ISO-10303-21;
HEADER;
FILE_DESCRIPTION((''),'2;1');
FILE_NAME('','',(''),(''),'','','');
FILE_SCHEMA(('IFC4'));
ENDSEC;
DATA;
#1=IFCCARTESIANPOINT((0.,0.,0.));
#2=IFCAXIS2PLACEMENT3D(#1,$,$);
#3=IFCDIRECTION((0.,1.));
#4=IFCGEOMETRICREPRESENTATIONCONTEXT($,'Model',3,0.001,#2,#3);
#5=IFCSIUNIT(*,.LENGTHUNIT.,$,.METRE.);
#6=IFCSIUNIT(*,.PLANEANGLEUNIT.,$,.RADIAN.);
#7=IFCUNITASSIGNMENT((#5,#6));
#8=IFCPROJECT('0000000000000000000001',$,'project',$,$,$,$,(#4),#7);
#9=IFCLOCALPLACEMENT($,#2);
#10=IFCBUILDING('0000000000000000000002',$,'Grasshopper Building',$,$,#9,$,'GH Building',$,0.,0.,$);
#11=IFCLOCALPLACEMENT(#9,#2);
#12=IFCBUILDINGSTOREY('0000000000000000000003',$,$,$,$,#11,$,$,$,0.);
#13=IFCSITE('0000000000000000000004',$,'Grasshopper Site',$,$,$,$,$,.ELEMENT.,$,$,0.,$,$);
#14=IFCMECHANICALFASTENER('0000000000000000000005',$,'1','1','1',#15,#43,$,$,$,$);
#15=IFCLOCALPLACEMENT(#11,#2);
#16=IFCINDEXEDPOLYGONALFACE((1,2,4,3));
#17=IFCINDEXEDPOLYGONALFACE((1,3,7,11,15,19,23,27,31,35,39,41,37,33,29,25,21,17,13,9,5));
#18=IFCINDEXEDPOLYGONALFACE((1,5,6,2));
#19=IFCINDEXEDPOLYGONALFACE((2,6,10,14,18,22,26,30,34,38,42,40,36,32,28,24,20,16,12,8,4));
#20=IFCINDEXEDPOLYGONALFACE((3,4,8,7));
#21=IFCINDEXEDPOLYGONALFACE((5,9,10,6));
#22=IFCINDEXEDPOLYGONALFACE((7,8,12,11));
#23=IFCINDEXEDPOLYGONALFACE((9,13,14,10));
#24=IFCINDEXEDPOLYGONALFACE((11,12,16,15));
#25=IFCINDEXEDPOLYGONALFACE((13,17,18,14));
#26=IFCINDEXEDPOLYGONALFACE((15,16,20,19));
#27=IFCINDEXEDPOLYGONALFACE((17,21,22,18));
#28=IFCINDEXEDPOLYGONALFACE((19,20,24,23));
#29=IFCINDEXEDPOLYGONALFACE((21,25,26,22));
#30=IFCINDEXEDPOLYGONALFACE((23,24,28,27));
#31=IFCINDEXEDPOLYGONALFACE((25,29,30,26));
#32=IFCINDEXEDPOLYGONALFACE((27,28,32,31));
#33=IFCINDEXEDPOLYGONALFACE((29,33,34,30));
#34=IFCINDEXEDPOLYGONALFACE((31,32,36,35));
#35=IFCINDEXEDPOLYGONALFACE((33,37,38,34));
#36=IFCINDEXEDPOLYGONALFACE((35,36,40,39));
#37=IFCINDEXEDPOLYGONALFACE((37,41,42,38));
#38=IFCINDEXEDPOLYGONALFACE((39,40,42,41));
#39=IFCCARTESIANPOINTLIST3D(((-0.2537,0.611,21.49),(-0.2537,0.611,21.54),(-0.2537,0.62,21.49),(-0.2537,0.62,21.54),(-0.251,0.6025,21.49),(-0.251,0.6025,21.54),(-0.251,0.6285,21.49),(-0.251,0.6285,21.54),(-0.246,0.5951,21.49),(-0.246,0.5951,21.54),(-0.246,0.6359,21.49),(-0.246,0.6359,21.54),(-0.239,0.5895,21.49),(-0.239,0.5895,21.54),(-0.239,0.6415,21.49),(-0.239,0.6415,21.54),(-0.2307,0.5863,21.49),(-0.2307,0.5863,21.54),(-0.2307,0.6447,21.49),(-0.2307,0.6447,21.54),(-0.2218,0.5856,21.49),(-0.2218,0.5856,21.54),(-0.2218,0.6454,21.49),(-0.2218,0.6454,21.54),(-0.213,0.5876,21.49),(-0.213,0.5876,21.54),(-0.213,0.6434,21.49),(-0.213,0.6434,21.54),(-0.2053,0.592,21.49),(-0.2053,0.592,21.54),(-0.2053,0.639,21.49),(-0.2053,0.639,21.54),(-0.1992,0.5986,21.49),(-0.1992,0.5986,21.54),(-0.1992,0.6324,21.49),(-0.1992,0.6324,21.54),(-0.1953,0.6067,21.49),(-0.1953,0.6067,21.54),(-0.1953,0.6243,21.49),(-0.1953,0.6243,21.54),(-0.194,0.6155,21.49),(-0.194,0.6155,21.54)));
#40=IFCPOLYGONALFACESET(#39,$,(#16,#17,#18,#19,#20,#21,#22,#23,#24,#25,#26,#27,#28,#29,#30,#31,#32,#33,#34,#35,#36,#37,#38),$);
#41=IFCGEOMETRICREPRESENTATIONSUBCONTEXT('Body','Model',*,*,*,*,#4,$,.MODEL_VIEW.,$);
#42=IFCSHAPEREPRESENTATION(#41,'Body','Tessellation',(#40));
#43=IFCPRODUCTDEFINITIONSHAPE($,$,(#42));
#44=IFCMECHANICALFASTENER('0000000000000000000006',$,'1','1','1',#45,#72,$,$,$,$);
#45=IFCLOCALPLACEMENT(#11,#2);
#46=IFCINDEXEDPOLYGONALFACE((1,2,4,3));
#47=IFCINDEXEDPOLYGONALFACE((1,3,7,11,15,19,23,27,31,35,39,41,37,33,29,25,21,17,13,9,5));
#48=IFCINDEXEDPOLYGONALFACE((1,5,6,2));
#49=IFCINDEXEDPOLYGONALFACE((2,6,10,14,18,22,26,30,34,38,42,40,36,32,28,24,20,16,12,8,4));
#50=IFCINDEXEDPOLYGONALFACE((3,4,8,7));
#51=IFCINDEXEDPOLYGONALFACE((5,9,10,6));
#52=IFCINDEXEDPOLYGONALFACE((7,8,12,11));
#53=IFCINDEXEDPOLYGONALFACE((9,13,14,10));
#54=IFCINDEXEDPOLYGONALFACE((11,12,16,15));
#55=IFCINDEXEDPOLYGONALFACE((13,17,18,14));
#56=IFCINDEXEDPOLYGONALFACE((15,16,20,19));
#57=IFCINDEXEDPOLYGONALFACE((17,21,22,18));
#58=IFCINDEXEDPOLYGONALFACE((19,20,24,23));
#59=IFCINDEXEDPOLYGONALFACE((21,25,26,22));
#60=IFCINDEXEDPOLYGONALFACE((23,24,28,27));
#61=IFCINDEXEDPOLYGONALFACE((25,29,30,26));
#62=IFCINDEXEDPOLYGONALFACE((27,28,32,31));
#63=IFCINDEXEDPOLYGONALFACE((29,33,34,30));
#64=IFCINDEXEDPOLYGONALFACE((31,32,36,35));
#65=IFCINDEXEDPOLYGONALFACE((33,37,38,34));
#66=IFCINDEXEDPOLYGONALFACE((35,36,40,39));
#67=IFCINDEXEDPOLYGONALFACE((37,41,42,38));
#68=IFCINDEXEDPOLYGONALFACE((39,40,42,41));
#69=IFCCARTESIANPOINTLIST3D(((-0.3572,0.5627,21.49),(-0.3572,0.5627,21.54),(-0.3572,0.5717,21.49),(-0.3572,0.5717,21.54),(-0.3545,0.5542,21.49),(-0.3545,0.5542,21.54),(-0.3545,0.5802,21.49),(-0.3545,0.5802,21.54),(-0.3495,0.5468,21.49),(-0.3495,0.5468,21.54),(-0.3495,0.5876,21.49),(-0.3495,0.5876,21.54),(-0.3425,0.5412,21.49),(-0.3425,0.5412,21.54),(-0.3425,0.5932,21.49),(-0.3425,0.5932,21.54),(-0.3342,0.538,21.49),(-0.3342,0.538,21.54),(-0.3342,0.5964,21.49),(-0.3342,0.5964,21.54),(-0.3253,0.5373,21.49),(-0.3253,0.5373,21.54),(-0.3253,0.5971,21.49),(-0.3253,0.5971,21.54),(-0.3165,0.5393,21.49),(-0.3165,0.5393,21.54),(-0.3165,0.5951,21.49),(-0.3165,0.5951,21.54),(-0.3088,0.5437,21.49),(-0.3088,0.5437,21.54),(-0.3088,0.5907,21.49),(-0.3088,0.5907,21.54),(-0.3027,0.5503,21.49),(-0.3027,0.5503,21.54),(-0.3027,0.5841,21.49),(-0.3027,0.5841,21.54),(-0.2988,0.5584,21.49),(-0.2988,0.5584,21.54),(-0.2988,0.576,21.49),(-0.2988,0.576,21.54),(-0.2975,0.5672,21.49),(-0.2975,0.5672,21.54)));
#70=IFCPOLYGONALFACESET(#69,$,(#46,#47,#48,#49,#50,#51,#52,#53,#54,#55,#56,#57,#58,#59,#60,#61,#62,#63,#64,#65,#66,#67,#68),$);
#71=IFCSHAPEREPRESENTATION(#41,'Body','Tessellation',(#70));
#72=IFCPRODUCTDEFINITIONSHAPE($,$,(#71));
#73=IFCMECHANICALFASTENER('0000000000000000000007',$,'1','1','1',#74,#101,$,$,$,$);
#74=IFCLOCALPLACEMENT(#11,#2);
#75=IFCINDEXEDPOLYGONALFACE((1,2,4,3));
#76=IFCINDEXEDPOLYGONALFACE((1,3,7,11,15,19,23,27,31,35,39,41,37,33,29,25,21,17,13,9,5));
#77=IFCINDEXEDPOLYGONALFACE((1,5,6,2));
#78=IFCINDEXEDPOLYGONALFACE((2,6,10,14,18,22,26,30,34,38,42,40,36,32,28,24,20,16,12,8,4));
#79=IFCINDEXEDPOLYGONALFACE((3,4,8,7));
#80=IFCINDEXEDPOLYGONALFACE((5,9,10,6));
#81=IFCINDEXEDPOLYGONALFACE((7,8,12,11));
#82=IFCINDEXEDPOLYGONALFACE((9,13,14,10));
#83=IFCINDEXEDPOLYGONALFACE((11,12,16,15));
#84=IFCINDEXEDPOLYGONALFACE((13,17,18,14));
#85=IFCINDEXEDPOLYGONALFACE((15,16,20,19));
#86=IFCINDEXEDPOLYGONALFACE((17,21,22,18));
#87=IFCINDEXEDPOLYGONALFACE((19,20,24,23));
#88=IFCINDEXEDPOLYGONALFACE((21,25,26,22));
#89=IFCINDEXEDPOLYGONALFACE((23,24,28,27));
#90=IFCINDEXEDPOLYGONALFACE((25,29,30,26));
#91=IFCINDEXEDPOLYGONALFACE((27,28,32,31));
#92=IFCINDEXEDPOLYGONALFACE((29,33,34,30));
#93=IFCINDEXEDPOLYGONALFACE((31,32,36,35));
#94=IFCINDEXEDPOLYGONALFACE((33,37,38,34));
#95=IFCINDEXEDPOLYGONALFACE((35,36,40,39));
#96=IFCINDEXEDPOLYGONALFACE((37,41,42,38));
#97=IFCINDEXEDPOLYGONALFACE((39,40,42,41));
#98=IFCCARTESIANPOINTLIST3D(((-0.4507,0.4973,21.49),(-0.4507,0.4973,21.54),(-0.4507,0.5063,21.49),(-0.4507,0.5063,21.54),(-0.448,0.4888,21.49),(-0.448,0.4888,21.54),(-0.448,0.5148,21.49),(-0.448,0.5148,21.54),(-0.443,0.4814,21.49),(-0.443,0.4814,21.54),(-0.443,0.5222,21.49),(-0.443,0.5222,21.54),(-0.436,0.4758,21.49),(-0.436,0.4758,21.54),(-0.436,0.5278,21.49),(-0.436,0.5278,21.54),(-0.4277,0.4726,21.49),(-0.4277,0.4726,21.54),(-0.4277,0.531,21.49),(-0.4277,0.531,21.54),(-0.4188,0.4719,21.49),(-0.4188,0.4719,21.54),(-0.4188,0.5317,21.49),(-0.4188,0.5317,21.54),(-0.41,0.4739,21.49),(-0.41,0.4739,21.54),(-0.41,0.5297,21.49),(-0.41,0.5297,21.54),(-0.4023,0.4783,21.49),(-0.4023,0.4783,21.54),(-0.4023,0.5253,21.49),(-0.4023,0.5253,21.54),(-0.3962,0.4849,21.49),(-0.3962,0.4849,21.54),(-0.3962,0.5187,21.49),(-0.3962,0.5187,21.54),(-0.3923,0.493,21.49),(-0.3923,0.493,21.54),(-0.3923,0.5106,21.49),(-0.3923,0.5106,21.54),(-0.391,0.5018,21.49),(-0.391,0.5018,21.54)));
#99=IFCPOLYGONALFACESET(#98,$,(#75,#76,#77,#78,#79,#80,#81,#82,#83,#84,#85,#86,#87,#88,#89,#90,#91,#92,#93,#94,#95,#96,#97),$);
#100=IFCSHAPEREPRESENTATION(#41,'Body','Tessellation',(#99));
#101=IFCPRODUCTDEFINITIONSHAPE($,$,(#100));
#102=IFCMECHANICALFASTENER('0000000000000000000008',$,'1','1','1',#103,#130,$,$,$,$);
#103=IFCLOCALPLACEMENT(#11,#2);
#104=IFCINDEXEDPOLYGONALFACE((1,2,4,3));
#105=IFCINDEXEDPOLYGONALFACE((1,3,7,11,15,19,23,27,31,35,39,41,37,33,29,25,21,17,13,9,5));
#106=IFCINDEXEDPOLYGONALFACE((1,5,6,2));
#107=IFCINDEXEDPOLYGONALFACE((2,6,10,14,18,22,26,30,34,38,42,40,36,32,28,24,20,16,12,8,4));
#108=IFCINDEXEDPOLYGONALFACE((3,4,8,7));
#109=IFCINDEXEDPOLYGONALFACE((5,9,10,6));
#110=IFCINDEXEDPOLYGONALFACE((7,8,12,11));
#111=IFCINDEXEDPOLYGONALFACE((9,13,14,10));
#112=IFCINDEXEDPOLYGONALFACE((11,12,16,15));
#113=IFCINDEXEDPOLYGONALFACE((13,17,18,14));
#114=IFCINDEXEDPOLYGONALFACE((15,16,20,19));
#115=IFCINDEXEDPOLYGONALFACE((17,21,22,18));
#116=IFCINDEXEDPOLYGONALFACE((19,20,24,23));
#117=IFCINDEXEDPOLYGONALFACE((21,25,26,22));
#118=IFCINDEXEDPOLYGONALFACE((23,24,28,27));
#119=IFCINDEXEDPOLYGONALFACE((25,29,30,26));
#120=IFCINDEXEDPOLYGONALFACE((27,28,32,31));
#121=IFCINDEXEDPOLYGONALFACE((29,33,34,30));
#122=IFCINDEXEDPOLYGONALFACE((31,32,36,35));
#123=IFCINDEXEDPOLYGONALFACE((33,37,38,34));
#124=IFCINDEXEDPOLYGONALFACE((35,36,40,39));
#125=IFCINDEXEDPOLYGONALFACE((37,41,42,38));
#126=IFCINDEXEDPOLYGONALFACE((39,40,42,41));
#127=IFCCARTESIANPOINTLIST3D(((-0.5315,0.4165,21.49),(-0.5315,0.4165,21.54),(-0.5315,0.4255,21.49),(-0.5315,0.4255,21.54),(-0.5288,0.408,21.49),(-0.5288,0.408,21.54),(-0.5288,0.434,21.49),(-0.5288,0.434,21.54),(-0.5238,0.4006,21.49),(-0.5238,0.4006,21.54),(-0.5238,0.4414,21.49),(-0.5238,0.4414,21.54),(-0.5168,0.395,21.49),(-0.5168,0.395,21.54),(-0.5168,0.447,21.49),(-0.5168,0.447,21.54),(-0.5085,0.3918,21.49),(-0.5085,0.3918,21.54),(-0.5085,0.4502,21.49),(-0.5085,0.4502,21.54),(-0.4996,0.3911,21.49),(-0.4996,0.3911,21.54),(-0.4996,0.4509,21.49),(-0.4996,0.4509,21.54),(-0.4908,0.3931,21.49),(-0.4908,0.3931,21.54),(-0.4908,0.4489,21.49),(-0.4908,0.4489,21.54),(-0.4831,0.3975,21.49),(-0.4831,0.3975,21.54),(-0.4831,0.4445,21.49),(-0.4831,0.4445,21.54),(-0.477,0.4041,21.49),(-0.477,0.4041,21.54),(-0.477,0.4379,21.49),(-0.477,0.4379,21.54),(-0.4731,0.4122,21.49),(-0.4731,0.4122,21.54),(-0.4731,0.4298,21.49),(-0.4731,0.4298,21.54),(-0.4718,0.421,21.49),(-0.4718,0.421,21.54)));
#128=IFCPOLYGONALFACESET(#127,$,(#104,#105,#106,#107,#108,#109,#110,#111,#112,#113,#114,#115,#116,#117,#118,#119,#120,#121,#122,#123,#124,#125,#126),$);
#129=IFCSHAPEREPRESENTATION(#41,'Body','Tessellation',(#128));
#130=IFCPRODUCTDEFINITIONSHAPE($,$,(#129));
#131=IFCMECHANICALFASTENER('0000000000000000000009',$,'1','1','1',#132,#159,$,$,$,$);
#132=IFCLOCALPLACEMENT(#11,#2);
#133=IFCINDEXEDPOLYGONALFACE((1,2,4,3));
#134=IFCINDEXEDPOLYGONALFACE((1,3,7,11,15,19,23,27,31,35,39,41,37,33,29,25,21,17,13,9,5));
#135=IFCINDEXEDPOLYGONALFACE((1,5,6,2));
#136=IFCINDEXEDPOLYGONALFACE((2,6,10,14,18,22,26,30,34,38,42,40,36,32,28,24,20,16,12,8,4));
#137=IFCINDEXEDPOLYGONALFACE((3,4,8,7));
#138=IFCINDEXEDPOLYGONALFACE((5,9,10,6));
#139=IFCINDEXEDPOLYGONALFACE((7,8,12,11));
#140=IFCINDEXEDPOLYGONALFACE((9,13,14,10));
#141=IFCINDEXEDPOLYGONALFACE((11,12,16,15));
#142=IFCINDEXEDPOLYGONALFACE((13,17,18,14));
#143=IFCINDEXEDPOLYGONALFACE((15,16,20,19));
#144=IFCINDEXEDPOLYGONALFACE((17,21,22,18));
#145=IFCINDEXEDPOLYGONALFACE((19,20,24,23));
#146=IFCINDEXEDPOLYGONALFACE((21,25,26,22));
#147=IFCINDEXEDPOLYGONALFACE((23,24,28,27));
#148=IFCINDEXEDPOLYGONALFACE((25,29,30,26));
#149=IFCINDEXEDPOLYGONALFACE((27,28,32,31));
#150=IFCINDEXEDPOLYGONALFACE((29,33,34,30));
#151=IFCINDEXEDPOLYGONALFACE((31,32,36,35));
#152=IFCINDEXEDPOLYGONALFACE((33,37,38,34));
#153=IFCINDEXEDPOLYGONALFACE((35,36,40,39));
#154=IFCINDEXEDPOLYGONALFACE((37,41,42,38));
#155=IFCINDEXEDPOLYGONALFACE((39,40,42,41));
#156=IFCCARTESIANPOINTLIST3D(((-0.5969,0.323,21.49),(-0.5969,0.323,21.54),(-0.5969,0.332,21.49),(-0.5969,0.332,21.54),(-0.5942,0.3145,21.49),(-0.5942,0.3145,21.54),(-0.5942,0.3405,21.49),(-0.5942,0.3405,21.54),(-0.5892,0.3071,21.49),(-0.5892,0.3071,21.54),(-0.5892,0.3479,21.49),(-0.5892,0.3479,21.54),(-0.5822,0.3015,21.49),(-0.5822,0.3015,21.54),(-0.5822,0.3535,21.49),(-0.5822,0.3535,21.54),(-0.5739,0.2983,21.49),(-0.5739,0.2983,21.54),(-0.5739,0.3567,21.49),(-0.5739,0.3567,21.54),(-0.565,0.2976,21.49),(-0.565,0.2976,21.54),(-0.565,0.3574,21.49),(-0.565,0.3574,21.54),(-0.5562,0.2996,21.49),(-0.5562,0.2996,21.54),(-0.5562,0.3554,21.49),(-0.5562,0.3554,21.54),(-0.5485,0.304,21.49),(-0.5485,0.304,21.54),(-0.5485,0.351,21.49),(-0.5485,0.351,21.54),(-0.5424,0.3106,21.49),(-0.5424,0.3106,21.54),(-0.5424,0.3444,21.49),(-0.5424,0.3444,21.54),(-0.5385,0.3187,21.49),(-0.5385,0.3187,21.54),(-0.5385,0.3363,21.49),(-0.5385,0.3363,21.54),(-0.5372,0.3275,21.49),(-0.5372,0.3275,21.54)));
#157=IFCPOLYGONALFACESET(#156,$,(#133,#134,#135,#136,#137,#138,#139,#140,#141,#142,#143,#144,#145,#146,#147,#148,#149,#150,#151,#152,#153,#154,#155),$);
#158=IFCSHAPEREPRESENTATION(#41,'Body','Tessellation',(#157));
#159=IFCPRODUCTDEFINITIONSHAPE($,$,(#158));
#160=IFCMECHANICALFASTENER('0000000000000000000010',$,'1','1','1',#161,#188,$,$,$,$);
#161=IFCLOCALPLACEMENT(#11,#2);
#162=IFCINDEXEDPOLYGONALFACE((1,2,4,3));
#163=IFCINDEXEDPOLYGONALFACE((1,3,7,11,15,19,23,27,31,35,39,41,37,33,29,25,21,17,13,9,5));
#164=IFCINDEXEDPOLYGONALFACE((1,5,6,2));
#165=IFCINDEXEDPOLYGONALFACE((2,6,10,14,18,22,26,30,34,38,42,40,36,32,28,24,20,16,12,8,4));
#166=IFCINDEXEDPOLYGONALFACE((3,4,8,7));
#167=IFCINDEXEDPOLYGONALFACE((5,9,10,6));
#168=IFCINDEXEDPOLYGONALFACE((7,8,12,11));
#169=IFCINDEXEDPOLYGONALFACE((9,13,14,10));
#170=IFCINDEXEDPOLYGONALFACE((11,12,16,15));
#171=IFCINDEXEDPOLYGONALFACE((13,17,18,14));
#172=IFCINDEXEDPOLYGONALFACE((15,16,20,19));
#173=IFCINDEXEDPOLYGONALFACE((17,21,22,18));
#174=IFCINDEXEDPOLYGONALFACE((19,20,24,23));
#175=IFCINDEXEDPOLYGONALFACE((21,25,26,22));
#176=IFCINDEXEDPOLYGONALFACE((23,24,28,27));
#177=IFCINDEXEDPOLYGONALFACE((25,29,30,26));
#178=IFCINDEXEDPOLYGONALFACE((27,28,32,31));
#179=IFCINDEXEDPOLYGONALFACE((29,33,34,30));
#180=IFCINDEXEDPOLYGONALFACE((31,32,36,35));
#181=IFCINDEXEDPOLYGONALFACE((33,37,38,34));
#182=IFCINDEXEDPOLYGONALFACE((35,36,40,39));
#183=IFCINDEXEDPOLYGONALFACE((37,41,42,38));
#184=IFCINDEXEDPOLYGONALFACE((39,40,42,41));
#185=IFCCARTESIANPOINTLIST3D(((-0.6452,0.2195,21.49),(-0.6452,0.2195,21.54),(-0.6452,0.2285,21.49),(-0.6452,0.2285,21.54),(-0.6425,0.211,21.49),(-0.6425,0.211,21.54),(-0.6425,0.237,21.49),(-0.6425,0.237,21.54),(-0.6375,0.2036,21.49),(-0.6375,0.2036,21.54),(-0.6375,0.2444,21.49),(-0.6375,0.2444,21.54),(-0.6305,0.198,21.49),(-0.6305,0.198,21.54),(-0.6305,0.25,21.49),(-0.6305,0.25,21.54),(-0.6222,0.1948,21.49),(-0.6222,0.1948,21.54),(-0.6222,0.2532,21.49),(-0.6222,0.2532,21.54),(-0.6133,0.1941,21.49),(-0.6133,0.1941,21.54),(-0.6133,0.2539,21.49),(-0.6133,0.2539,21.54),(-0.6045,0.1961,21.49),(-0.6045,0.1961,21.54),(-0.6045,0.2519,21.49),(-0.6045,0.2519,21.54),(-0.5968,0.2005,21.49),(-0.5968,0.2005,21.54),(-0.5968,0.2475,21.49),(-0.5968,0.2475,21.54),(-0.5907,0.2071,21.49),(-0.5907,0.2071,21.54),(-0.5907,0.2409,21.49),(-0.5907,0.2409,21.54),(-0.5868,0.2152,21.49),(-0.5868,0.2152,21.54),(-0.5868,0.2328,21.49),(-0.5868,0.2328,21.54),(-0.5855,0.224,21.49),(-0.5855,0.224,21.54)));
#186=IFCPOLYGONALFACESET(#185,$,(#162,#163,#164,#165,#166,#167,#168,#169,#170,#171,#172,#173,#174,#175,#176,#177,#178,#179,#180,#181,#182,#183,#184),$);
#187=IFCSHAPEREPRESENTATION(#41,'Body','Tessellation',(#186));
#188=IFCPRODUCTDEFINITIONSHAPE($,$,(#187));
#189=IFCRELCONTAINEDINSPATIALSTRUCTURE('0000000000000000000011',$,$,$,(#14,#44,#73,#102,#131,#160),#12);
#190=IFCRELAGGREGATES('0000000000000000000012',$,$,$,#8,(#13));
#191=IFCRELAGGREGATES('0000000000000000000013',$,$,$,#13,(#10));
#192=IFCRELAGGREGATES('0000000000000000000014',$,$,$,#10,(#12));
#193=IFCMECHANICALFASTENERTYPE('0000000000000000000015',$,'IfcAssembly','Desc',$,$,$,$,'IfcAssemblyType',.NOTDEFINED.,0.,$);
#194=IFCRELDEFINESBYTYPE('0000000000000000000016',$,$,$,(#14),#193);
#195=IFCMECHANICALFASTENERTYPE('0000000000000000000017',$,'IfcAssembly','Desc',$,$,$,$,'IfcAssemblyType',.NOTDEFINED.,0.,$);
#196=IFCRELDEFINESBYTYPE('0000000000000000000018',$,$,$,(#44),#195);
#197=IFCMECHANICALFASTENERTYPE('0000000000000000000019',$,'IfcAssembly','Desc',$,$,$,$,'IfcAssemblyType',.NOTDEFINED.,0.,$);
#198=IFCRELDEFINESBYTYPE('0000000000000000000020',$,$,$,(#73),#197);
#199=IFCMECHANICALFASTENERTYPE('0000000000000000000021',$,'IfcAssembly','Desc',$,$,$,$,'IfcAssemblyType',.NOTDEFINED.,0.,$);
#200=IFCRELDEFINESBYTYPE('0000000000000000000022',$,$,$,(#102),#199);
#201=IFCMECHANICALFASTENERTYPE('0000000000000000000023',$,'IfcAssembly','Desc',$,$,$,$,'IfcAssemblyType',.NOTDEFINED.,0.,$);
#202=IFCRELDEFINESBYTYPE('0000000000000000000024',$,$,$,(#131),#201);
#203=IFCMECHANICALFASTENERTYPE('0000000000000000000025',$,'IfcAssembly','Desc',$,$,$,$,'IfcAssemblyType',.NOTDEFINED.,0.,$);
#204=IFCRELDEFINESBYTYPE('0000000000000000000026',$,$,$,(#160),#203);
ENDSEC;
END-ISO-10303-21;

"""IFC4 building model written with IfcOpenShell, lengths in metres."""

from ifc_helpers import new_model, si_unit, direction, frame, origin, place, context, subcontext, project, spatial, circle, extrude, source, transform, mapped, type_object, type_shapes, element, save


model = new_model("IFC4")

# Units and contexts
model_context = context("Model", 3, precision=0.001, world=origin(), true_north=direction((0.0, 1.0)))
body_context = subcontext(model_context, "Body", "Model", "MODEL_VIEW")
ifc_project = project(units=[si_unit("LENGTHUNIT", "METRE"), si_unit("PLANEANGLEUNIT", "RADIAN")], contexts=[model_context])

# Site, building, storey
site = spatial("IfcSite", under=ifc_project, Name="Grasshopper Site", CompositionType="ELEMENT", RefElevation=0.0)
building_placement = place(None, origin())
building = spatial("IfcBuilding", under=site, at=building_placement, Name="Grasshopper Building", LongName="GH Building", ElevationOfRefHeight=0.0, ElevationOfTerrain=0.0)
storey_placement = place(building_placement, origin())
storey = spatial("IfcBuildingStorey", under=building, at=storey_placement, Elevation=0.0)

# Mechanical fasteners
mechanical_fastener_type_1 = type_object("IfcMechanicalFastenerType", Name="IfcAssembly", Description="Desc", ElementType="IfcAssemblyType", NominalDiameter=0.0)
shared_shape_1 = source(origin(), body_context, "Body", "SweptSolid", [
    extrude(circle(Radius=0.03), frame((-0.224, 0.6155, 21.54), z_axis=(0.0, 0.0, -1.0), x_axis=(1.0, 0.0, 0.0)), (0.0, 0.0, 1.0), 0.05),
])
type_shapes(mechanical_fastener_type_1, [shared_shape_1])
mechanical_fastener_1_placement = place(storey_placement, origin())
element("IfcMechanicalFastener", 1, at=mechanical_fastener_1_placement, inside=storey, type_object=mechanical_fastener_type_1, Name="1", Description="1", ObjectType="1", context=body_context, shape_type="MappedRepresentation", body=[
    mapped(shared_shape_1, transform((0.0, 0.0, 0.0), scale=1.0)),
])
mechanical_fastener_type_2 = type_object("IfcMechanicalFastenerType", Name="IfcAssembly", Description="Desc", ElementType="IfcAssemblyType", NominalDiameter=0.0)
shared_shape_2 = source(origin(), body_context, "Body", "SweptSolid", [
    extrude(circle(Radius=0.03), frame((-0.3275, 0.5672, 21.54), z_axis=(0.0, 0.0, -1.0), x_axis=(1.0, 0.0, 0.0)), (0.0, 0.0, 1.0), 0.05),
])
type_shapes(mechanical_fastener_type_2, [shared_shape_2])
mechanical_fastener_2_placement = place(storey_placement, origin())
element("IfcMechanicalFastener", 2, at=mechanical_fastener_2_placement, inside=storey, type_object=mechanical_fastener_type_2, Name="1", Description="1", ObjectType="1", context=body_context, shape_type="MappedRepresentation", body=[
    mapped(shared_shape_2, transform((0.0, 0.0, 0.0), scale=1.0)),
])
mechanical_fastener_type_3 = type_object("IfcMechanicalFastenerType", Name="IfcAssembly", Description="Desc", ElementType="IfcAssemblyType", NominalDiameter=0.0)
shared_shape_3 = source(origin(), body_context, "Body", "SweptSolid", [
    extrude(circle(Radius=0.03), frame((-0.421, 0.5018, 21.54), z_axis=(0.0, 0.0, -1.0), x_axis=(1.0, 0.0, 0.0)), (0.0, 0.0, 1.0), 0.05),
])
type_shapes(mechanical_fastener_type_3, [shared_shape_3])
mechanical_fastener_3_placement = place(storey_placement, origin())
element("IfcMechanicalFastener", 3, at=mechanical_fastener_3_placement, inside=storey, type_object=mechanical_fastener_type_3, Name="1", Description="1", ObjectType="1", context=body_context, shape_type="MappedRepresentation", body=[
    mapped(shared_shape_3, transform((0.0, 0.0, 0.0), scale=1.0)),
])
mechanical_fastener_type_4 = type_object("IfcMechanicalFastenerType", Name="IfcAssembly", Description="Desc", ElementType="IfcAssemblyType", NominalDiameter=0.0)
shared_shape_4 = source(origin(), body_context, "Body", "SweptSolid", [
    extrude(circle(Radius=0.03), frame((-0.5018, 0.421, 21.54), z_axis=(0.0, 0.0, -1.0), x_axis=(1.0, 0.0, 0.0)), (0.0, 0.0, 1.0), 0.05),
])
type_shapes(mechanical_fastener_type_4, [shared_shape_4])
mechanical_fastener_4_placement = place(storey_placement, origin())
element("IfcMechanicalFastener", 4, at=mechanical_fastener_4_placement, inside=storey, type_object=mechanical_fastener_type_4, Name="1", Description="1", ObjectType="1", context=body_context, shape_type="MappedRepresentation", body=[
    mapped(shared_shape_4, transform((0.0, 0.0, 0.0), scale=1.0)),
])
mechanical_fastener_type_5 = type_object("IfcMechanicalFastenerType", Name="IfcAssembly", Description="Desc", ElementType="IfcAssemblyType", NominalDiameter=0.0)
shared_shape_5 = source(origin(), body_context, "Body", "SweptSolid", [
    extrude(circle(Radius=0.03), frame((-0.5672, 0.3275, 21.54), z_axis=(0.0, 0.0, -1.0), x_axis=(1.0, 0.0, 0.0)), (0.0, 0.0, 1.0), 0.05),
])
type_shapes(mechanical_fastener_type_5, [shared_shape_5])
mechanical_fastener_5_placement = place(storey_placement, origin())
element("IfcMechanicalFastener", 5, at=mechanical_fastener_5_placement, inside=storey, type_object=mechanical_fastener_type_5, Name="1", Description="1", ObjectType="1", context=body_context, shape_type="MappedRepresentation", body=[
    mapped(shared_shape_5, transform((0.0, 0.0, 0.0), scale=1.0)),
])
mechanical_fastener_type_6 = type_object("IfcMechanicalFastenerType", Name="IfcAssembly", Description="Desc", ElementType="IfcAssemblyType", NominalDiameter=0.0)
shared_shape_6 = source(origin(), body_context, "Body", "SweptSolid", [
    extrude(circle(Radius=0.03), frame((-0.6155, 0.224, 21.54), z_axis=(0.0, 0.0, -1.0), x_axis=(1.0, 0.0, 0.0)), (0.0, 0.0, 1.0), 0.05),
])
type_shapes(mechanical_fastener_type_6, [shared_shape_6])
mechanical_fastener_6_placement = place(storey_placement, origin())
element("IfcMechanicalFastener", 6, at=mechanical_fastener_6_placement, inside=storey, type_object=mechanical_fastener_type_6, Name="1", Description="1", ObjectType="1", context=body_context, shape_type="MappedRepresentation", body=[
    mapped(shared_shape_6, transform((0.0, 0.0, 0.0), scale=1.0)),
])

save(model, "model.ifc")
